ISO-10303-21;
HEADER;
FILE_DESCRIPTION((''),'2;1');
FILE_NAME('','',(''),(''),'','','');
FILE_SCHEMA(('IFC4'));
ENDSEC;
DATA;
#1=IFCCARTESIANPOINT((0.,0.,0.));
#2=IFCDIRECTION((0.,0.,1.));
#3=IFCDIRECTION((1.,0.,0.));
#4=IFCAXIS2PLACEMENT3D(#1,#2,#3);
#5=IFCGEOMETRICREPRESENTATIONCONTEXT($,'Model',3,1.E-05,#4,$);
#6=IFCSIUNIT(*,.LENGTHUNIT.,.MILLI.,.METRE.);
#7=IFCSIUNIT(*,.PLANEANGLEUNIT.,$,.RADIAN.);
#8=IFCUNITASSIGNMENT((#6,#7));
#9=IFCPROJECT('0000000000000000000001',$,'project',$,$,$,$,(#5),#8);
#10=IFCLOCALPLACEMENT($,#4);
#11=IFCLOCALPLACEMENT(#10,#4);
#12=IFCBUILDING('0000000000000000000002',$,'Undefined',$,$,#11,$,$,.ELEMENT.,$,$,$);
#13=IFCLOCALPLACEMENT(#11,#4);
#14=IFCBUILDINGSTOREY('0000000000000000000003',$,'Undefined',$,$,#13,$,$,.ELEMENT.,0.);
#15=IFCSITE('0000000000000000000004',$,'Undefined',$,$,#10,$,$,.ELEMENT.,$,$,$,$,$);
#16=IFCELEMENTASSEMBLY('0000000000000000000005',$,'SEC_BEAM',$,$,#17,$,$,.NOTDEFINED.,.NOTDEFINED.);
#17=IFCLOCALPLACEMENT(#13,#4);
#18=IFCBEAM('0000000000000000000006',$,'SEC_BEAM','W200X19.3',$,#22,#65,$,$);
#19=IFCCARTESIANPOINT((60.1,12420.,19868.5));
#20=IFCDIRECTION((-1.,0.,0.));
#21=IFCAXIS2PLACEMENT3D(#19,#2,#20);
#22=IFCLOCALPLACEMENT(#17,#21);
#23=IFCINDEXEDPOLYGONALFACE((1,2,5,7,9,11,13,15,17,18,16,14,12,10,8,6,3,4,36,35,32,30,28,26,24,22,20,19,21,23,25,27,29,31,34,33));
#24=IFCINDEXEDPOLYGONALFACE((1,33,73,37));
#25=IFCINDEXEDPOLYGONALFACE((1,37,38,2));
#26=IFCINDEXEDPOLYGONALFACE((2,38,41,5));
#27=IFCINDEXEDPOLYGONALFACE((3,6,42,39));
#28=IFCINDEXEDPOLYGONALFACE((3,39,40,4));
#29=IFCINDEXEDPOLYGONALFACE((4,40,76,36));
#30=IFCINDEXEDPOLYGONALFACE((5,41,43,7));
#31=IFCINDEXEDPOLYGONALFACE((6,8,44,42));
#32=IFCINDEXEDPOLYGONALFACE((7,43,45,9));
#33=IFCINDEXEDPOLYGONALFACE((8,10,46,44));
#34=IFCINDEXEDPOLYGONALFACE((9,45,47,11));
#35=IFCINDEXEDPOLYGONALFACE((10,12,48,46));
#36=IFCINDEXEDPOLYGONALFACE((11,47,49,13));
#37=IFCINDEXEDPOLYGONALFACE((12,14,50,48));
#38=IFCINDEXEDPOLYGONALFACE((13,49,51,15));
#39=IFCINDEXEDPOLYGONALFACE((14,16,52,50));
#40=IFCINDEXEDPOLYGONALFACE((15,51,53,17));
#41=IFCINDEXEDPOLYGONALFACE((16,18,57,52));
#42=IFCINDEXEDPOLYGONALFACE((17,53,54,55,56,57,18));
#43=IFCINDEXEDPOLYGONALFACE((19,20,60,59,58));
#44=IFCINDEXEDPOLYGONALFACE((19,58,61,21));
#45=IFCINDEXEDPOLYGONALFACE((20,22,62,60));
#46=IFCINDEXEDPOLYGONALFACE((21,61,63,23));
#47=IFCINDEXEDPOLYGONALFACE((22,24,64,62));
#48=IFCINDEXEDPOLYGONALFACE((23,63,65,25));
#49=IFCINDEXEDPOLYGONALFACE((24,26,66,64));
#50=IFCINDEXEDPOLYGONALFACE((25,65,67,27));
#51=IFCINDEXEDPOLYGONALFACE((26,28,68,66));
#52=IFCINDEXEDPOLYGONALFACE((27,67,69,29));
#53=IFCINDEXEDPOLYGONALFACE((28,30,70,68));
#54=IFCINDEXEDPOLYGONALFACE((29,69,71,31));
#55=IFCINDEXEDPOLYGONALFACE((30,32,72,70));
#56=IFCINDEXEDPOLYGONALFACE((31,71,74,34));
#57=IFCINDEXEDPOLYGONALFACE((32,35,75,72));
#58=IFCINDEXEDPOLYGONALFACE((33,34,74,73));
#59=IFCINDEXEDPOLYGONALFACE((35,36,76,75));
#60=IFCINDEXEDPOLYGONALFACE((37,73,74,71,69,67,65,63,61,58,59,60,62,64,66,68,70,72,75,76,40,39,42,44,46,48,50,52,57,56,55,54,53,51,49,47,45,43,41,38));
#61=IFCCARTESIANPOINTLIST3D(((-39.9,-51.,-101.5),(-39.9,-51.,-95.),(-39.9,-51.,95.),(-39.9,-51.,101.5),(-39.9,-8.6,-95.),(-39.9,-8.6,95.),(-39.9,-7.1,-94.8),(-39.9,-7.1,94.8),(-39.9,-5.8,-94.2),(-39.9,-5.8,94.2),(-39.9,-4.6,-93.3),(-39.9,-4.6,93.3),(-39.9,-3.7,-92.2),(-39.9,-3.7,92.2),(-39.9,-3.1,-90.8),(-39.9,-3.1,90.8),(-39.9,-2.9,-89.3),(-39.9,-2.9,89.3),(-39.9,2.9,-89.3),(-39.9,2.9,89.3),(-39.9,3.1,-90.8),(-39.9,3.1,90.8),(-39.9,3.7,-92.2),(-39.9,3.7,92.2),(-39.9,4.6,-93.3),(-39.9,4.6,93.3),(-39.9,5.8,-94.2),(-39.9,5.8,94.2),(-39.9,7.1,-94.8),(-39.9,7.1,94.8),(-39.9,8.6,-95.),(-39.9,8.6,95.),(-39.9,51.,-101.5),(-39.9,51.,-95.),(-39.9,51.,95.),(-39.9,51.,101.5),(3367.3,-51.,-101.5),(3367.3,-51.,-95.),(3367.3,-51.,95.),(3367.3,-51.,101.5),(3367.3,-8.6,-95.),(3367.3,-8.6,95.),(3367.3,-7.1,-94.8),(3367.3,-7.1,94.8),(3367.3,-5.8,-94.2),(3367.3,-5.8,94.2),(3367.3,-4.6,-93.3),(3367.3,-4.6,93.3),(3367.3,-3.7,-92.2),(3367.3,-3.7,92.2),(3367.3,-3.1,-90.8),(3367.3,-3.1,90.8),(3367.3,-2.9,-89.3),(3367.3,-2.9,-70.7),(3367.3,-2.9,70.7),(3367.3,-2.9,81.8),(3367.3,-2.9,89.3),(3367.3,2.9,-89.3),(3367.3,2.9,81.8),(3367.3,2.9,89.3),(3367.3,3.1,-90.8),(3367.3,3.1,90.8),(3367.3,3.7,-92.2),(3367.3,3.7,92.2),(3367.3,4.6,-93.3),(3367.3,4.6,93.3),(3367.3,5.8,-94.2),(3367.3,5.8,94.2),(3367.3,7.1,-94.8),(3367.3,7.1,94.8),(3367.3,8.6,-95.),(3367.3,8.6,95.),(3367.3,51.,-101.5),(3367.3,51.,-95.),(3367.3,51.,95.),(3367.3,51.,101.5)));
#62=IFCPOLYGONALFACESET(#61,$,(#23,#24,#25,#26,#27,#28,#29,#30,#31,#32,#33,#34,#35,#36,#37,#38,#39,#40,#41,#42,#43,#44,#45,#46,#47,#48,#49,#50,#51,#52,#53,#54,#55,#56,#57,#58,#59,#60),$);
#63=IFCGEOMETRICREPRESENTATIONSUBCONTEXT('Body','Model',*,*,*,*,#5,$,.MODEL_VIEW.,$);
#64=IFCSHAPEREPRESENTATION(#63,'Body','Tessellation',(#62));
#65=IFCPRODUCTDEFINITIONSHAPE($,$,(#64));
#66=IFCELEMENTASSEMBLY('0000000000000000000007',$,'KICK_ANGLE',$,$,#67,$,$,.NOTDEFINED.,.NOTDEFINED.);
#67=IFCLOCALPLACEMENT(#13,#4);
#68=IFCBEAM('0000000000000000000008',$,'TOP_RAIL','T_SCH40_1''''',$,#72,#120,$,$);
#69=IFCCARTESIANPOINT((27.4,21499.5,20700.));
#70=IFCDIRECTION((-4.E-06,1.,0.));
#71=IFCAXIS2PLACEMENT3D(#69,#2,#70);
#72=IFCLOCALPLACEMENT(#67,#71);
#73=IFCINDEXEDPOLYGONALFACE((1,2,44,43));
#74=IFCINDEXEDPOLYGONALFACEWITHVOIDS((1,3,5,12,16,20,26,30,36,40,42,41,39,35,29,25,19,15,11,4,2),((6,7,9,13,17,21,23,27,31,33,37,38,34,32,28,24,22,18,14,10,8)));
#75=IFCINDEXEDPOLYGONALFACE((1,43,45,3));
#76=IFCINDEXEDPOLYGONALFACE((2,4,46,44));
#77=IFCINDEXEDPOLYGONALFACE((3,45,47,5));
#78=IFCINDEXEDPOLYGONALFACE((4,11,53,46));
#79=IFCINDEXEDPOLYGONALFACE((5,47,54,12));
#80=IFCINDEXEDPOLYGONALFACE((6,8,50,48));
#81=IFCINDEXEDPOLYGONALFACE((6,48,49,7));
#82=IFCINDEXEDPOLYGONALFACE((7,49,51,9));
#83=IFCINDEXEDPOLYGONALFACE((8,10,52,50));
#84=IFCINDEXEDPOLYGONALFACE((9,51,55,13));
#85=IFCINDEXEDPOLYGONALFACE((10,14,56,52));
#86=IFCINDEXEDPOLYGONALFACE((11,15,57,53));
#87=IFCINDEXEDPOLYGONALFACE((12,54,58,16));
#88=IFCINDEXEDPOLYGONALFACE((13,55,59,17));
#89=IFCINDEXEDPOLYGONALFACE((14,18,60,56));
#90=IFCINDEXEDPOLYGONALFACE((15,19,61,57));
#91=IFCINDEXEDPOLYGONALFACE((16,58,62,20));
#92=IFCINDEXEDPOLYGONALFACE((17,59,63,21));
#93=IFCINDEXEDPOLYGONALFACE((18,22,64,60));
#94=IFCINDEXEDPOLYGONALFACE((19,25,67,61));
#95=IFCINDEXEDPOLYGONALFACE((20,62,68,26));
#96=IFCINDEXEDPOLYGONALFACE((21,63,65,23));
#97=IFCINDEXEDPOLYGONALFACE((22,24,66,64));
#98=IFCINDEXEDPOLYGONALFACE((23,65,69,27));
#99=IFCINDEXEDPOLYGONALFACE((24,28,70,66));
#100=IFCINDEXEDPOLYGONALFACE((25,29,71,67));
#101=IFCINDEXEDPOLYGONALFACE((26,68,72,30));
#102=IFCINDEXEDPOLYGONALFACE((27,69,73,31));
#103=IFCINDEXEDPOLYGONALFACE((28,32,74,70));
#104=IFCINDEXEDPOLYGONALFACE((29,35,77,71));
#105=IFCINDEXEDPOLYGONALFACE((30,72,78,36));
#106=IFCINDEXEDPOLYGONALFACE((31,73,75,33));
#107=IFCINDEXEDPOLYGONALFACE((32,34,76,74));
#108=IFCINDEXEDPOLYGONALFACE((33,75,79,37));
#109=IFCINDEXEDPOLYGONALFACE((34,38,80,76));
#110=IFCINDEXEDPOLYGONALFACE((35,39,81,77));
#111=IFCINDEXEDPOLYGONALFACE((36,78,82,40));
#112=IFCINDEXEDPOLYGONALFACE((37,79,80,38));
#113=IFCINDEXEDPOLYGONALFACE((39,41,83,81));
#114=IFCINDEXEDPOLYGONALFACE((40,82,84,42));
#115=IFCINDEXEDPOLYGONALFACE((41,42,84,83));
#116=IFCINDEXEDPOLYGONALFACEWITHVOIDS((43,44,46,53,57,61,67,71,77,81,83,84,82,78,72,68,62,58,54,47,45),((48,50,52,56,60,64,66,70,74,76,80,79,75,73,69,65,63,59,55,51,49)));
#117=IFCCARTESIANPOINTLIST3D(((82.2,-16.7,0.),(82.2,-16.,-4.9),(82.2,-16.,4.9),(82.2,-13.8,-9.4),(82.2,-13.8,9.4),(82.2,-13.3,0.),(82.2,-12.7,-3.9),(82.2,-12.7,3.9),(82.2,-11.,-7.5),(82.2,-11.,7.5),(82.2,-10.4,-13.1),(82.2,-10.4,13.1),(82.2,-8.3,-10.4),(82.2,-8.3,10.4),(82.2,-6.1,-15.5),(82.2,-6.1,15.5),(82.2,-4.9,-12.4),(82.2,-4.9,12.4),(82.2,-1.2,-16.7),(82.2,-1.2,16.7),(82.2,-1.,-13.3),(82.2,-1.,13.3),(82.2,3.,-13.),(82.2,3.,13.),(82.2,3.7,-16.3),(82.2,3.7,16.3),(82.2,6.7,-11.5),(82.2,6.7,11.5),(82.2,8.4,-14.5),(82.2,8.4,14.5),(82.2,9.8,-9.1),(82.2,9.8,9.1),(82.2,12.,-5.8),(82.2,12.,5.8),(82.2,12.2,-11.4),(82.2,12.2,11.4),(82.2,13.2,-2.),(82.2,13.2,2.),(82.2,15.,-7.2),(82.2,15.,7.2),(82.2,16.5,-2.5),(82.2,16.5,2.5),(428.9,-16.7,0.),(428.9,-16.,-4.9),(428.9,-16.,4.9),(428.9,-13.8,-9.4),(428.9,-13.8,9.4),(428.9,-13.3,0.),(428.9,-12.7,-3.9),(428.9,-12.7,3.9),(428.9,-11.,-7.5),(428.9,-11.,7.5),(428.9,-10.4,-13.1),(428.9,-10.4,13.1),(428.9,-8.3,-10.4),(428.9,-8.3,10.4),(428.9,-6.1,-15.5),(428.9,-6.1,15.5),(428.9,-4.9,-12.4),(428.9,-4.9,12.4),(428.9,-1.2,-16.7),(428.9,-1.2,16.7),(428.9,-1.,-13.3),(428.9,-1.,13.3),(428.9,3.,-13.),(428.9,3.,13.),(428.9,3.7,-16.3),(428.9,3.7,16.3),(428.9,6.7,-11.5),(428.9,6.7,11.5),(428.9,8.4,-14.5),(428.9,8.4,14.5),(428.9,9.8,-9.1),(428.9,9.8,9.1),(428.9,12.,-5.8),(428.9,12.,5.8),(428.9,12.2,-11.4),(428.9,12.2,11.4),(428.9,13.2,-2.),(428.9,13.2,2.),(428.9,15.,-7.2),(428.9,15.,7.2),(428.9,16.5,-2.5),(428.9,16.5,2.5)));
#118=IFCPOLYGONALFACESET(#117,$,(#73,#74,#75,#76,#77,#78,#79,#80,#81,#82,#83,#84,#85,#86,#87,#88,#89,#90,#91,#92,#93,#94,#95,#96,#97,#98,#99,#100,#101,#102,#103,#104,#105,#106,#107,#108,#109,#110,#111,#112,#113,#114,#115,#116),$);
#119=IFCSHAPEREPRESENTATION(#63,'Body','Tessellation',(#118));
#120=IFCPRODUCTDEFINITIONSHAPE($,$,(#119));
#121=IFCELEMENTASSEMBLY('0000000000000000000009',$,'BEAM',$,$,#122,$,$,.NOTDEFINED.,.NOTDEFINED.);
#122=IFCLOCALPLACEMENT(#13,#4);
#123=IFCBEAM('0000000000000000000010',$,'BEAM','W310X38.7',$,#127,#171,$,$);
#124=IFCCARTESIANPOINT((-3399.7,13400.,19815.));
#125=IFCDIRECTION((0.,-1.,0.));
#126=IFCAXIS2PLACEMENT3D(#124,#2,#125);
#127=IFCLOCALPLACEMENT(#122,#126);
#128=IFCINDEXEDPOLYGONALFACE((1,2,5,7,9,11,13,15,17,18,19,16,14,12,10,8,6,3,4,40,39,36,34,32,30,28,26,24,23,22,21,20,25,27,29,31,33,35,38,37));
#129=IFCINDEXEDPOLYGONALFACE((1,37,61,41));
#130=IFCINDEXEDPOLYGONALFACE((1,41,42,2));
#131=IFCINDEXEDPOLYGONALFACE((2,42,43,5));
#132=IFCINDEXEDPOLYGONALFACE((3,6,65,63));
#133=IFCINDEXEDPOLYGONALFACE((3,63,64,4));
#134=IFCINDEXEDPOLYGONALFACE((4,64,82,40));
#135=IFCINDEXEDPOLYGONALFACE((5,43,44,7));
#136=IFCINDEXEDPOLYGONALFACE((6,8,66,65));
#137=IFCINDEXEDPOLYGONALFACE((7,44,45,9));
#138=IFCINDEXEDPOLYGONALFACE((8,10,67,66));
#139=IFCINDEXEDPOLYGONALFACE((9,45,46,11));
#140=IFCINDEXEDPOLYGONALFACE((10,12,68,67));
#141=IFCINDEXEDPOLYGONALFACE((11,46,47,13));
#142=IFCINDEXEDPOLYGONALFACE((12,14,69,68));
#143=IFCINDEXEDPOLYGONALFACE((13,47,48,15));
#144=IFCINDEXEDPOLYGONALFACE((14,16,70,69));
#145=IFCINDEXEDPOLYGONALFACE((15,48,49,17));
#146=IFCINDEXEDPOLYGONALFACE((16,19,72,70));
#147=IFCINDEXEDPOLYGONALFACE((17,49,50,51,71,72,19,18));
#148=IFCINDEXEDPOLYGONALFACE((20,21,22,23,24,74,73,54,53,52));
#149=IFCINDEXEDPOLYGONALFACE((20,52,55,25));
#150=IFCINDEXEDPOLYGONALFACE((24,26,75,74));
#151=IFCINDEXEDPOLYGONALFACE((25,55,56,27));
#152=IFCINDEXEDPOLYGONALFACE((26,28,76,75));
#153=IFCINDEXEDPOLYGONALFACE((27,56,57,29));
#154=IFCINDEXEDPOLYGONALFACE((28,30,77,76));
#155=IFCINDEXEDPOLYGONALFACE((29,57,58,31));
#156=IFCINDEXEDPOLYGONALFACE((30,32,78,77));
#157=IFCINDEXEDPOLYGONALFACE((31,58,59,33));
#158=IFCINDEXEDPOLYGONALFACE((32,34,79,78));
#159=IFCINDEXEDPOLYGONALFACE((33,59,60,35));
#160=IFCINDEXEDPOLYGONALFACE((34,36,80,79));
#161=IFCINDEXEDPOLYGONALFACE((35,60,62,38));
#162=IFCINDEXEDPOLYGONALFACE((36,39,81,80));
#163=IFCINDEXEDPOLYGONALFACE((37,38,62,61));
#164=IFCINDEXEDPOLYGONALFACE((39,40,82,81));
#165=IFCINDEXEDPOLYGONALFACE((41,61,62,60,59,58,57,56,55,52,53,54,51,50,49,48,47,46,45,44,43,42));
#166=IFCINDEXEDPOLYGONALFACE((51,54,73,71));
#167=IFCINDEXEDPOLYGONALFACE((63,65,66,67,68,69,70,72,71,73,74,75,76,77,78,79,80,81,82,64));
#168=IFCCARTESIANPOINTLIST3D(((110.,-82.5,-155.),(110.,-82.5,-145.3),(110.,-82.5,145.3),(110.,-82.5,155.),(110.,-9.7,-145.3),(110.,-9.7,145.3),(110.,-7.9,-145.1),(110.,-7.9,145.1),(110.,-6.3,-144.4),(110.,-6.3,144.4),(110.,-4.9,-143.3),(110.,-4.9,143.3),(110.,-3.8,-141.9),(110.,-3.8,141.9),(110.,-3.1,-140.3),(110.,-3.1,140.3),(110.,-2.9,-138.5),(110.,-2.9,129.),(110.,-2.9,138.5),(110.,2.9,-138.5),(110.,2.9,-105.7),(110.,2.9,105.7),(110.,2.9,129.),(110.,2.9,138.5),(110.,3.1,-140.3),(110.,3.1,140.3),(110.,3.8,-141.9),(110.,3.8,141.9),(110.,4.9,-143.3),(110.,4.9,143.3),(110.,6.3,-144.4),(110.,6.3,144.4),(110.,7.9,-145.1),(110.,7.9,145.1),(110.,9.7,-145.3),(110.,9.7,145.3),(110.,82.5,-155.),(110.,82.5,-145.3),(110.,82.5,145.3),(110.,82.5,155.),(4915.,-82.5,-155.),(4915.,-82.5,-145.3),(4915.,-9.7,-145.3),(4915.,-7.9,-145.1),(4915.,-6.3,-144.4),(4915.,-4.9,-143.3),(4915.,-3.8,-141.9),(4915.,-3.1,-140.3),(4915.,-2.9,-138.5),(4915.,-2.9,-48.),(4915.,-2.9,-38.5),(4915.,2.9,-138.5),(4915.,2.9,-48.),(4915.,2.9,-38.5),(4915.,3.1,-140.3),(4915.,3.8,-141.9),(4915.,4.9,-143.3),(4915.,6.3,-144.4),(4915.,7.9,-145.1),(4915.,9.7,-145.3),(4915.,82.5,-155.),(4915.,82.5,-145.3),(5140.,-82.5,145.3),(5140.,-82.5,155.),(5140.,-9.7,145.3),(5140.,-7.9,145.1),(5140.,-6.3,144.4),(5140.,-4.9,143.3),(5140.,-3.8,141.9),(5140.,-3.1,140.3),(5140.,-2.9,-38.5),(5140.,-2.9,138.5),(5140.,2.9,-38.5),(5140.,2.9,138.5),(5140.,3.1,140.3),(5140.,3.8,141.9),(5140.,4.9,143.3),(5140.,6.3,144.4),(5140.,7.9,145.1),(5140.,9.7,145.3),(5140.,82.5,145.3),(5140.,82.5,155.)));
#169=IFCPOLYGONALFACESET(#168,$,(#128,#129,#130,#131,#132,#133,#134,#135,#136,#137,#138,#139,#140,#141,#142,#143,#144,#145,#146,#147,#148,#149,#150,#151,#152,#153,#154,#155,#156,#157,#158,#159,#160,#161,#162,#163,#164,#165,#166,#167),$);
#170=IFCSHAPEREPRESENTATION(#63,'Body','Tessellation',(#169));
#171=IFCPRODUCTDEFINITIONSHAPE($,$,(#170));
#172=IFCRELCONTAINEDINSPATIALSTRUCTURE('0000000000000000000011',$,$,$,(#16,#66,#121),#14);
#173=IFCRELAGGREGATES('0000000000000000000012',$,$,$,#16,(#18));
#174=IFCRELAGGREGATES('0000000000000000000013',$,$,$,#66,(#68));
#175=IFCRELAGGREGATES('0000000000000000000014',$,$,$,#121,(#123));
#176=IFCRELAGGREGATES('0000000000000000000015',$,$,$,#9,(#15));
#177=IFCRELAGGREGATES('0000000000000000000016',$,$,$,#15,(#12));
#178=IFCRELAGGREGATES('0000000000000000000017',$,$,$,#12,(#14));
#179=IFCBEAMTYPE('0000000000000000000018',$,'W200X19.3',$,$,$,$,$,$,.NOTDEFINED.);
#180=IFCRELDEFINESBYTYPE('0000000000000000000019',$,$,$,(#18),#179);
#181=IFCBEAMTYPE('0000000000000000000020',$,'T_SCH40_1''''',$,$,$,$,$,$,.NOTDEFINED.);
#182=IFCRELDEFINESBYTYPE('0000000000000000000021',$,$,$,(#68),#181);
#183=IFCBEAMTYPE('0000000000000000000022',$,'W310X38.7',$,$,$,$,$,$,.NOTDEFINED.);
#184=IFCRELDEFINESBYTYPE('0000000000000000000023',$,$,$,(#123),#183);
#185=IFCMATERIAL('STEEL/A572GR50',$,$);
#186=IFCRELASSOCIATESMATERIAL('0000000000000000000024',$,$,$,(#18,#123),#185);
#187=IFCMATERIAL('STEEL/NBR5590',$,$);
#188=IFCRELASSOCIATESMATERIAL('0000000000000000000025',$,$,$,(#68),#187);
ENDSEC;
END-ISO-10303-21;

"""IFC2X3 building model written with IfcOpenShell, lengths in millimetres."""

from ifc_helpers import new_model, si_unit, frame, origin_with_axes, origin_2d_with_axis, place, context, subcontext, project, spatial, polyline, rectangle, hollow_circle, i_section, outline, extrude, boolean, clip, halfspace, material, type_object, element, aggregate, save


model = new_model("IFC2X3")

# Units and contexts
model_context = context("Model", 3, precision=1e-05, world=origin_with_axes())
body_context = subcontext(model_context, "Body", "Model", "MODEL_VIEW")
ifc_project = project(units=[si_unit("LENGTHUNIT", "METRE", prefix="MILLI"), si_unit("PLANEANGLEUNIT", "RADIAN")], contexts=[model_context])

# Site, building, storey
site_placement = place(None, origin_with_axes())
site = spatial("IfcSite", under=ifc_project, at=site_placement, Name="Undefined", CompositionType="ELEMENT")
building_placement = place(site_placement, origin_with_axes())
building = spatial("IfcBuilding", under=site, at=building_placement, Name="Undefined", CompositionType="ELEMENT")
storey_placement = place(building_placement, origin_with_axes())
storey = spatial("IfcBuildingStorey", under=building, at=storey_placement, Name="Undefined", CompositionType="ELEMENT", Elevation=0.0)

# Shared definitions
ifc_material_1 = material(Name="STEEL/A572GR50")
ifc_material_2 = material(Name="STEEL/NBR5590")

# Element assembly, beam
assembly_1_placement = place(storey_placement, origin_with_axes())
assembly_1 = element("IfcElementAssembly", 1, at=assembly_1_placement, inside=storey, Name="SEC_BEAM", AssemblyPlace="NOTDEFINED", PredefinedType="NOTDEFINED")
beam_type_1 = type_object("IfcBeamType", Name="W200X19.3", PredefinedType="NOTDEFINED")
beam_1_placement = place(assembly_1_placement, frame((60.1, 12420.0, 19868.5), z_axis=(0.0, 0.0, 1.0), x_axis=(-1.0, 0.0, 0.0)))
beam_1 = element("IfcBeam", 2, at=beam_1_placement, type_object=beam_type_1, material=ifc_material_1, Name="SEC_BEAM", Description="W200X19.3", context=body_context, shape_type="CSG", body=[
    boolean("DIFFERENCE", boolean("DIFFERENCE", boolean("DIFFERENCE", boolean("DIFFERENCE", extrude(i_section(OverallWidth=102.0, OverallDepth=203.0, WebThickness=5.8, FlangeThickness=6.5, FilletRadius=5.7, at=origin_2d_with_axis()), frame((3459.8, 0.0, 0.0), z_axis=(-1.0, 0.0, 0.0), x_axis=(0.0, -1.0, 0.0)), (0.0, 0.0, 1.0), 3499.7), extrude(outline(polyline([(0.0, 0.0), (29.7, 0.0), (29.7, 10.0), (0.0, 10.0), (0.0, 0.0)])), frame((3367.3, -61.0, 81.8), z_axis=(0.0, 1.0, 0.0), x_axis=(0.0, 0.0, 1.0)), (0.0, 0.0, 1.0), 122.0)), extrude(rectangle(XDim=159.6, YDim=159.6, at=origin_2d_with_axis()), frame((3377.1, -82.7, 70.7), z_axis=(0.0, 0.0, -1.0), x_axis=(-1.0, 0.0, 0.0)), (0.0, 0.0, 1.0), 141.5)), halfspace(frame((3367.3, 0.0, 201.5), z_axis=(1.0, 0.0, 0.0), x_axis=(0.0, 1.0, 0.0)), False)), halfspace(frame((-39.9, 0.0, 0.0), z_axis=(1.0, 0.0, 0.0), x_axis=(0.0, -1.0, 0.0)), True)),
])
aggregate(assembly_1, [beam_1])

# Shared definitions
beam_type_2 = type_object("IfcBeamType", Name="T_SCH40_1''", PredefinedType="NOTDEFINED")

# Element assembly, beam
assembly_2_placement = place(storey_placement, origin_with_axes())
assembly_2 = element("IfcElementAssembly", 3, at=assembly_2_placement, inside=storey, Name="KICK_ANGLE", AssemblyPlace="NOTDEFINED", PredefinedType="NOTDEFINED")
beam_2_placement = place(assembly_2_placement, frame((27.4, 21499.5, 20700.0), z_axis=(0.0, 0.0, 1.0), x_axis=(-0.000004, 1.0, 0.0)))
beam_2 = element("IfcBeam", 4, at=beam_2_placement, type_object=beam_type_2, material=ifc_material_2, Name="TOP_RAIL", Description="T_SCH40_1''", context=body_context, shape_type="Clipping", body=[
    clip(extrude(hollow_circle(Radius=16.7, WallThickness=3.4, at=origin_2d_with_axis()), frame((428.9, 0.0, 0.0), z_axis=(-1.0, 0.0, 0.0), x_axis=(0.0, -1.0, 0.0)), (0.0, 0.0, 1.0), 428.9), halfspace(frame((82.2, 0.0, 0.0), z_axis=(1.0, 0.0, 0.0), x_axis=(0.0, -1.0, 0.0)), True)),
])

aggregate(assembly_2, [beam_2])

# Element assembly, beam
assembly_3_placement = place(storey_placement, origin_with_axes())
assembly_3 = element("IfcElementAssembly", 5, at=assembly_3_placement, inside=storey, Name="BEAM", AssemblyPlace="NOTDEFINED", PredefinedType="NOTDEFINED")
beam_type_3 = type_object("IfcBeamType", Name="W310X38.7", PredefinedType="NOTDEFINED")
beam_3_placement = place(assembly_3_placement, frame((-3399.7, 13400.0, 19815.0), z_axis=(0.0, 0.0, 1.0), x_axis=(0.0, -1.0, 0.0)))
beam_3 = element("IfcBeam", 6, at=beam_3_placement, type_object=beam_type_3, material=ifc_material_1, Name="BEAM", Description="W310X38.7", context=body_context, shape_type="CSG", body=[
    boolean("DIFFERENCE", boolean("DIFFERENCE", boolean("DIFFERENCE", boolean("DIFFERENCE", boolean("DIFFERENCE", boolean("DIFFERENCE", extrude(i_section(OverallWidth=165.0, OverallDepth=310.0, WebThickness=5.8, FlangeThickness=9.7, FilletRadius=6.8, at=origin_2d_with_axis()), frame((5140.0, 0.0, 0.0), z_axis=(-1.0, 0.0, 0.0), x_axis=(0.0, -1.0, 0.0)), (0.0, 0.0, 1.0), 5140.0), extrude(outline(polyline([(0.0, 0.0), (121.5, 0.0), (121.5, 225.0), (0.0, 225.0), (0.0, 0.0)])), frame((5140.0, -87.5, -38.5), z_axis=(0.0, 1.0, 0.0), x_axis=(0.0, 0.0, -1.0)), (0.0, 0.0, 1.0), 175.0)), extrude(rectangle(XDim=9.5, YDim=165.0, at=origin_2d_with_axis()), frame((4915.0, 0.0, -43.2), z_axis=(1.0, 0.0, 0.0), x_axis=(0.0, 0.0, -1.0)), (0.0, 0.0, 1.0), 225.0)), extrude(outline(polyline([(0.0, 0.0), (36.0, 0.0), (36.0, 10.0), (0.0, 10.0), (0.0, 0.0)])), frame((110.0, 92.5, 129.0), z_axis=(0.0, -1.0, 0.0), x_axis=(0.0, 0.0, 1.0)), (0.0, 0.0, 1.0), 185.0)), extrude(rectangle(XDim=176.0, YDim=176.0, at=origin_2d_with_axis()), frame((92.0, 90.9, 105.7), z_axis=(0.0, 0.0, -1.0), x_axis=(1.0, 0.0, 0.0)), (0.0, 0.0, 1.0), 211.5)), halfspace(frame((5140.0, 0.0, 0.0), z_axis=(-1.0, 0.0, 0.0), x_axis=(0.0, 1.0, 0.0)), True)), halfspace(frame((110.0, 0.0, 255.0), z_axis=(-1.0, 0.0, 0.0), x_axis=(0.0, -1.0, 0.0)), False)),
])

aggregate(assembly_3, [beam_3])

save(model, "model.ifc")
